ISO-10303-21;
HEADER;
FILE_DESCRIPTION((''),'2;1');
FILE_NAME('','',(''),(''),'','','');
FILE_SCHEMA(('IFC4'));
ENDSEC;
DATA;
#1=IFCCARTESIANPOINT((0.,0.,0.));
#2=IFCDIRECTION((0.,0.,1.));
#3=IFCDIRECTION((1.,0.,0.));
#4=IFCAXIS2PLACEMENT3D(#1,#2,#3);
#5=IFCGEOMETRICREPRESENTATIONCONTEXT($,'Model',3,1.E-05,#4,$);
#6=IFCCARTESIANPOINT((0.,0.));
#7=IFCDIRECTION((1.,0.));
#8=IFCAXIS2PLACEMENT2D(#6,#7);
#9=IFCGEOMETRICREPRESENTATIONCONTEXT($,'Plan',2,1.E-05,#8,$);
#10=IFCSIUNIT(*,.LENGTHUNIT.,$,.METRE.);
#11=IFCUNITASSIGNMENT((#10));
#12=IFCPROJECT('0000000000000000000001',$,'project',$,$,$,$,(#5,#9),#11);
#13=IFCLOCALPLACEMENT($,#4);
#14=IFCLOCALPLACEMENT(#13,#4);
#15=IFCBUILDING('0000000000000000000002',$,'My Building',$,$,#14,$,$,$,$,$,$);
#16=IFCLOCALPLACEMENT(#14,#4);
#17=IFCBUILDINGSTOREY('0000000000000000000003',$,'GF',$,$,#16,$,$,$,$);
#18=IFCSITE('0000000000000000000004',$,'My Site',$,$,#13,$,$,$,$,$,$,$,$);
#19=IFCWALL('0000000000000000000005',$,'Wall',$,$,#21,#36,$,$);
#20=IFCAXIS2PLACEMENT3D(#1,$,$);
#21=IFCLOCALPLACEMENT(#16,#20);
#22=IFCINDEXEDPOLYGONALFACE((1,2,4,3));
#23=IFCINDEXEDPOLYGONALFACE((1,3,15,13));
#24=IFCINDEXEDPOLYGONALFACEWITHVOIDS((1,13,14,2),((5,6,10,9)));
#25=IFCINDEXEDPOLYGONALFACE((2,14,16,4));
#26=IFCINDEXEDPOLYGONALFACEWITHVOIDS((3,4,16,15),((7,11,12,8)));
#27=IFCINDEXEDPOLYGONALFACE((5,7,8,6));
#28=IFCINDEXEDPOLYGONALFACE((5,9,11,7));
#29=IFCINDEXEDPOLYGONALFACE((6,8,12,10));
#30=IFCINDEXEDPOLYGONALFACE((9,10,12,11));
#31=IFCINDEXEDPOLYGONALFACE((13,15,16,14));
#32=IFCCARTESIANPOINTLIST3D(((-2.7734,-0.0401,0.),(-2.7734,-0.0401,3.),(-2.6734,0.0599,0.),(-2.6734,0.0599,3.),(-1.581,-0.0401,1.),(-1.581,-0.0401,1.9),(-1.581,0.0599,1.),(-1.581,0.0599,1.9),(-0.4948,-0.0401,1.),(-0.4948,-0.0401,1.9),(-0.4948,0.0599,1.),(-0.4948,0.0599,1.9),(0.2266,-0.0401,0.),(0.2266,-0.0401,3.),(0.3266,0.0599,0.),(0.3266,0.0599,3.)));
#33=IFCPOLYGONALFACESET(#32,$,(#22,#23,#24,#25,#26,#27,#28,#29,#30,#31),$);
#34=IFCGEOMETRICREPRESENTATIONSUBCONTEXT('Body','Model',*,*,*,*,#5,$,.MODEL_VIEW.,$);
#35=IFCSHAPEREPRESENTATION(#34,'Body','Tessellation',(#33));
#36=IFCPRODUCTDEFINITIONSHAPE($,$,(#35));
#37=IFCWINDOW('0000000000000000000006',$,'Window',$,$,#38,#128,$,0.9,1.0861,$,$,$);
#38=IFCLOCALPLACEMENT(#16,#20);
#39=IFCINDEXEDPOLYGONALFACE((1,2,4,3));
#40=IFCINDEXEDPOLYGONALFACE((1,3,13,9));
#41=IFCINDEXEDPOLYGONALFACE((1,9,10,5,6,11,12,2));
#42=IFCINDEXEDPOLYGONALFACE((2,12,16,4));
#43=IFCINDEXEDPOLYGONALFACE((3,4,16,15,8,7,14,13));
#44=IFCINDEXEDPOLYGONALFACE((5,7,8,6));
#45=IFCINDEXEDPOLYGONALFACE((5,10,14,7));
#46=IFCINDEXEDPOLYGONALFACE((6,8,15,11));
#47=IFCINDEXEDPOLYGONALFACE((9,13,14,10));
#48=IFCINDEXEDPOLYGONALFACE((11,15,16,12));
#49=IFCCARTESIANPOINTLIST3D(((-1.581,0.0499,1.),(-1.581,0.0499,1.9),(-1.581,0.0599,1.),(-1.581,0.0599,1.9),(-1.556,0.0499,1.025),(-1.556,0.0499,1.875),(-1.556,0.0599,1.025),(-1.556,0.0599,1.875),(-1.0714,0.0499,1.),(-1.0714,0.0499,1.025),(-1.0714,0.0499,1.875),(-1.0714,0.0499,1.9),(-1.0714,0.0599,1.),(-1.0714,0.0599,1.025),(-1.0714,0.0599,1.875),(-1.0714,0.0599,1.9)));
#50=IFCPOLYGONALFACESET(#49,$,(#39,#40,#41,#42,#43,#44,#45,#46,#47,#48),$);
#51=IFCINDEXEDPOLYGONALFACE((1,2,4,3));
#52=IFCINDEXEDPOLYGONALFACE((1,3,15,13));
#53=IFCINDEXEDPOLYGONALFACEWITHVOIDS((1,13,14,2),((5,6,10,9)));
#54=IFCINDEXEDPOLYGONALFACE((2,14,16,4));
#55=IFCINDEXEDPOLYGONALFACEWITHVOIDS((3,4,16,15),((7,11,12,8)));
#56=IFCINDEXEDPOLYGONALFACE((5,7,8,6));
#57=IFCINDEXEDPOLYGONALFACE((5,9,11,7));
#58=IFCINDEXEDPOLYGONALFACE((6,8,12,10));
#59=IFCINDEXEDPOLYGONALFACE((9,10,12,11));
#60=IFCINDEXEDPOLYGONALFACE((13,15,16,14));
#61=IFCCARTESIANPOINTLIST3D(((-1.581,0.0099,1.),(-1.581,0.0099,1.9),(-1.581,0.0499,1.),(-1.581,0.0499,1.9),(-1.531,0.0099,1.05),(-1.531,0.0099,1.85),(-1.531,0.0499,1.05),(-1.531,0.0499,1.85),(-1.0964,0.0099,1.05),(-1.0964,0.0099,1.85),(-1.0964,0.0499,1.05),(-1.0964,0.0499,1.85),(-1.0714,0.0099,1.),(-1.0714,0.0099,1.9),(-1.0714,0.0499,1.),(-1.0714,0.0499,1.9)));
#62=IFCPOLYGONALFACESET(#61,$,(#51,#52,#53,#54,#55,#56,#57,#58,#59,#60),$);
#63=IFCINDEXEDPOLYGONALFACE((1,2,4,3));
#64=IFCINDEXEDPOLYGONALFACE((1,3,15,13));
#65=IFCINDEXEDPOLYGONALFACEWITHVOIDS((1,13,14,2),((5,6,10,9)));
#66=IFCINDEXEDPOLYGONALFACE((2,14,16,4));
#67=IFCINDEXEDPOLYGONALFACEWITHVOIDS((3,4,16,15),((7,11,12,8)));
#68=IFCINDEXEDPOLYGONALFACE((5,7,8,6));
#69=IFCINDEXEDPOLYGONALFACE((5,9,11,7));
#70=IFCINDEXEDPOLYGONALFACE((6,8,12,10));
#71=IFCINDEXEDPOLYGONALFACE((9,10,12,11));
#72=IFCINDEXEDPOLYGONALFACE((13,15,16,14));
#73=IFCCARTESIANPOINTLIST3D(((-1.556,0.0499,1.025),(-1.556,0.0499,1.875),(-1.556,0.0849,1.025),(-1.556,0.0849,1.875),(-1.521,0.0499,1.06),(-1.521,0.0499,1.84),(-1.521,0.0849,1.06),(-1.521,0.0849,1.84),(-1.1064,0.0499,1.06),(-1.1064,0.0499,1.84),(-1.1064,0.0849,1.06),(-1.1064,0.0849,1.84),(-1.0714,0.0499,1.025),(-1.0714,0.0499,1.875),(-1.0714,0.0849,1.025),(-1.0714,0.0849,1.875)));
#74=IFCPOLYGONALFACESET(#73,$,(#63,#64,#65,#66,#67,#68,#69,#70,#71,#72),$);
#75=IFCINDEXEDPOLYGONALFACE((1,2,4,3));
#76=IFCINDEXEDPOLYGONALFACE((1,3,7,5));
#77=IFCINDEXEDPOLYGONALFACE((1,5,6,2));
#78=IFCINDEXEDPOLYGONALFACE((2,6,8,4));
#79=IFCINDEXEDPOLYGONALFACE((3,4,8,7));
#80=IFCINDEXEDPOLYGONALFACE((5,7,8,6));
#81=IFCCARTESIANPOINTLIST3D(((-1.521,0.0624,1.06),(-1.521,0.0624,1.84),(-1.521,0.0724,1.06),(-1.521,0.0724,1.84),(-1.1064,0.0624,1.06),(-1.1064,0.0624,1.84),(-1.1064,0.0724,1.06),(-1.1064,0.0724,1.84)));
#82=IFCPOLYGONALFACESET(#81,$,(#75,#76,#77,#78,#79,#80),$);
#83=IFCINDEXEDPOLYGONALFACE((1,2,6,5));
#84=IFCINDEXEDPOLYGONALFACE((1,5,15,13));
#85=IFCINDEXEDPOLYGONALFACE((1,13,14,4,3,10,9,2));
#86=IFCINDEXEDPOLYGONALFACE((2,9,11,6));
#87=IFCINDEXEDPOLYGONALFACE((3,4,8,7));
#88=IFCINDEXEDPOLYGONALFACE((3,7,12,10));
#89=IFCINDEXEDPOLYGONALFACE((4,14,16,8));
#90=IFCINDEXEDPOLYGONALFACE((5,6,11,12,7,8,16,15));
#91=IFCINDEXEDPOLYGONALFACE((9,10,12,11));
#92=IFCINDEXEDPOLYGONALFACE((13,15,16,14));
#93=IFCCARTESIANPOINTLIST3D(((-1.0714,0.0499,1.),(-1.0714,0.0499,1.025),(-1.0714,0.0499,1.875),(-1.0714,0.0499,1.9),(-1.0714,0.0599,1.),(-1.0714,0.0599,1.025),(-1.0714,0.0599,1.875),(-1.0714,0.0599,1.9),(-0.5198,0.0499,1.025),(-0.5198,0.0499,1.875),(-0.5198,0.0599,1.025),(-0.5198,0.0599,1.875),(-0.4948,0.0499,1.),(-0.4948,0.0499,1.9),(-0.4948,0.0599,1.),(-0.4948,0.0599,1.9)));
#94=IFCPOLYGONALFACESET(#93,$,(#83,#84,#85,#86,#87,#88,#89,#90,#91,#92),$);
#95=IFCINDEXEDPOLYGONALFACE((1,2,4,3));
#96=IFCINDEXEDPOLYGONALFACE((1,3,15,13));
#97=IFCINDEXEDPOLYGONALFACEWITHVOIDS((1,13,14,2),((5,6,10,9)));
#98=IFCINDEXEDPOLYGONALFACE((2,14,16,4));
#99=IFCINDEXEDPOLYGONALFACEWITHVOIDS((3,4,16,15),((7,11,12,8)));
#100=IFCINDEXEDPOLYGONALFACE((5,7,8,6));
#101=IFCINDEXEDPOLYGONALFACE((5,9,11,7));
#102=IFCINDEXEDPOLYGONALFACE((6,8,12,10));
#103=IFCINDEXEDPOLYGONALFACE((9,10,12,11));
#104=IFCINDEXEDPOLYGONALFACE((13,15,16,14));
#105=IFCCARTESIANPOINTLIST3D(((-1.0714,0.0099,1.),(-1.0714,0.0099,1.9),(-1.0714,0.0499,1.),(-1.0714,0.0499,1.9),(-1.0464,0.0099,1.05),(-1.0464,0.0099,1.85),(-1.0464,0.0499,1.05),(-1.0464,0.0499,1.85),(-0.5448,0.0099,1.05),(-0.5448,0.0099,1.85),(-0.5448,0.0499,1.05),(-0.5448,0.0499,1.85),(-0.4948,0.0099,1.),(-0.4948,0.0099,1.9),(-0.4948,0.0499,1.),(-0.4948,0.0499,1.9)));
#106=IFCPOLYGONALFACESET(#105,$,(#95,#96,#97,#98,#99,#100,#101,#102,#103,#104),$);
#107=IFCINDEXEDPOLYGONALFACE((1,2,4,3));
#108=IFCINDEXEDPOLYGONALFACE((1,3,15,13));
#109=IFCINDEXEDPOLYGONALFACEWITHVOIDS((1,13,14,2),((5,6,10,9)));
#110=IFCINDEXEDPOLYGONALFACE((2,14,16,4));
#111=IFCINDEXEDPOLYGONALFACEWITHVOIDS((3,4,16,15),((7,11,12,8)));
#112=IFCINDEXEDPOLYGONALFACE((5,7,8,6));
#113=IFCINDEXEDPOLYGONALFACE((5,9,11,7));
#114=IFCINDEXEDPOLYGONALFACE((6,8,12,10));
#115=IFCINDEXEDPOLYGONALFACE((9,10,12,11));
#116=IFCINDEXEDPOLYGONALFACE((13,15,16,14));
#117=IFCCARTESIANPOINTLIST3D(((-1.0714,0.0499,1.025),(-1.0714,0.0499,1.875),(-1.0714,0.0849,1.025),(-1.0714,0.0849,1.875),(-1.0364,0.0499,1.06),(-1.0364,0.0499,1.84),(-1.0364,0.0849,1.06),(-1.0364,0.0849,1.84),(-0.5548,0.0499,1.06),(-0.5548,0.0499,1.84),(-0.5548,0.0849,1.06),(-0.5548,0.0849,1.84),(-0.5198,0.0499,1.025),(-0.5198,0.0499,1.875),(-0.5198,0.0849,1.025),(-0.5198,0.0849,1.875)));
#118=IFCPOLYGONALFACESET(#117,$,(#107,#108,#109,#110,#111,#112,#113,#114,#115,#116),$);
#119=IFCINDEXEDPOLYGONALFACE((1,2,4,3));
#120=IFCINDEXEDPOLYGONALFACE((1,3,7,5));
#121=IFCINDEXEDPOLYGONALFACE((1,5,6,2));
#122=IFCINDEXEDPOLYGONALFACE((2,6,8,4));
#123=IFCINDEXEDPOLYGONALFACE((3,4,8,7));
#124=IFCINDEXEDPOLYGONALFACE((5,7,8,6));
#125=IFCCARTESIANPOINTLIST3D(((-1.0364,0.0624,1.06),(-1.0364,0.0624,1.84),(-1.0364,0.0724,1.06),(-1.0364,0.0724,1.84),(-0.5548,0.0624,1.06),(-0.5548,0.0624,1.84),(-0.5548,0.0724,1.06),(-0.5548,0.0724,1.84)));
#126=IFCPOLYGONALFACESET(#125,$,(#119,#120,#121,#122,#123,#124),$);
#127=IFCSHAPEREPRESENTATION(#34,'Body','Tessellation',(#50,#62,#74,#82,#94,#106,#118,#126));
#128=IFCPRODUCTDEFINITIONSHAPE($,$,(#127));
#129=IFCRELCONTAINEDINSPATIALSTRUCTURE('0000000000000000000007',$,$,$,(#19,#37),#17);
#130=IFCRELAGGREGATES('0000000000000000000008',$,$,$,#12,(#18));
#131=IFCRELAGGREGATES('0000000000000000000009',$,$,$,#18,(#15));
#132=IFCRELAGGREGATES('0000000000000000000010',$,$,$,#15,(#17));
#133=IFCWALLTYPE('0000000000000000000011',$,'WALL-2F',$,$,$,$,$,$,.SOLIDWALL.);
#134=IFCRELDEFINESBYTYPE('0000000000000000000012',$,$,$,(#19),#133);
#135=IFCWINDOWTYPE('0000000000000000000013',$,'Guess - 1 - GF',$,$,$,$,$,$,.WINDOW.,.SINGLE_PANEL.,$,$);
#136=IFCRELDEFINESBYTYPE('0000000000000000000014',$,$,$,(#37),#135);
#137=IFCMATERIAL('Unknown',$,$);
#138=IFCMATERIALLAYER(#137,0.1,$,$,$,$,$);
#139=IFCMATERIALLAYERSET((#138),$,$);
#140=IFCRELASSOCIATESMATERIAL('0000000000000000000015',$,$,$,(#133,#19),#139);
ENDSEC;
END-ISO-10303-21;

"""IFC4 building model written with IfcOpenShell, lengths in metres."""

from ifc_helpers import new_model, entity, si_unit, frame, origin_with_axes, origin_2d_with_axis, place, context, subcontext, project, spatial, line, indexed_curve, outline, extrude, shape, source, transform, mapped, material, layer, layer_set, layer_usage, type_object, type_shapes, element, fill, save


model = new_model("IFC4")

# Units and contexts
model_context = context("Model", 3, precision=1e-05, world=origin_with_axes())
plan_context = context("Plan", 2, precision=1e-05, world=origin_2d_with_axis())
body_context_1 = subcontext(model_context, "Body", "Model", "MODEL_VIEW")
body_context_2 = subcontext(plan_context, "Body", "Plan", "PLAN_VIEW")
ifc_project = project(units=[si_unit("LENGTHUNIT", "METRE")], contexts=[model_context, plan_context])

# Site, building, storey
site_placement = place(None, origin_with_axes())
site = spatial("IfcSite", under=ifc_project, at=site_placement, Name="My Site")
building_placement = place(site_placement, origin_with_axes())
building = spatial("IfcBuilding", under=site, at=building_placement, Name="My Building")
storey_placement = place(building_placement, origin_with_axes())
storey = spatial("IfcBuildingStorey", under=building, at=storey_placement, Name="GF")

# Shared definitions
ifc_material_1 = material(Name="Unknown")

# Shared definitions
ifc_layer_1 = layer(ifc_material_1, 0.1)
ifc_layer_set_1 = layer_set([ifc_layer_1])
wall_type_1 = type_object("IfcWallType", Name="WALL-2F", PredefinedType="SOLIDWALL", material=ifc_layer_set_1)

# Wall, opening, window
ifc_layer_usage_1 = layer_usage(ifc_layer_set_1, "AXIS2", "POSITIVE", 0.0)
wall_1_placement = place(storey_placement, frame((-2.7734, -0.0401, 0.0), z_axis=(0.0, 0.0, 1.0), x_axis=(1.0, 0.0, 0.0)))
wall_1 = element("IfcWall", 1, at=wall_1_placement, inside=storey, type_object=wall_type_1, material=ifc_layer_usage_1, Name="Wall", context=body_context_1, shape_type="SweptSolid", body=[
    extrude(outline(indexed_curve([(0.0, 0.0), (0.1, 0.1), (3.1, 0.1), (3.0, 0.0)], segments=[line(1, 2, 3, 4, 1)])), origin_with_axes(), (0.0, 0.0, 1.0), 3.0),
])
shared_shape_1 = source(origin_with_axes(), body_context_1, "Body", "SweptSolid", [
    extrude(outline(indexed_curve([(0.0, 0.0), (1.0861, 0.0), (1.0861, 0.9), (0.0, 0.9)], segments=[line(1, 2, 3, 4, 1)])), frame((0.0, -0.6, 0.0), z_axis=(0.0, -1.0, 0.0), x_axis=(1.0, 0.0, 0.0)), (0.0, 0.0, -1.0), 1.2),
])
opening_1_placement = place(wall_1_placement, frame((1.1924, 0.0, 1.0), z_axis=(0.0, 0.0, 1.0), x_axis=(1.0, 0.0, 0.0)))
opening_1 = element("IfcOpeningElement", 2, at=opening_1_placement, cuts=wall_1, PredefinedType="OPENING", context=body_context_1, shape_type="MappedRepresentation", body=[
    mapped(shared_shape_1, transform((0.0, 0.0, 0.0), x_axis=(1.0, 0.0, 0.0), y_axis=(0.0, 1.0, 0.0), z_axis=(0.0, 0.0, 1.0), scale=1.0)),
])
window_type_1 = type_object("IfcWindowType", Name="Guess - 1 - GF", PartitioningType="SINGLE_PANEL", PredefinedType="WINDOW")
shared_shape_2 = source(origin_with_axes(), body_context_1, "Body", "SweptSolid", [
    extrude(outline(indexed_curve([(0.5096, 0.0), (0.0, 0.0), (0.0, 0.9), (0.5096, 0.9), (0.5096, 0.875), (0.025, 0.875), (0.025, 0.025), (0.5096, 0.025)], segments=[line(1, 2, 3, 4, 5, 6, 7, 8, 1)])), frame((0.0, 0.09, 0.0), z_axis=(0.0, -1.0, 0.0), x_axis=(1.0, 0.0, 0.0)), (0.0, 0.0, -1.0), 0.01),
    extrude(outline(indexed_curve([(0.0, 0.0), (0.5096, 0.0), (0.5096, 0.9), (0.0, 0.9)], segments=[line(1, 2, 3, 4, 1)]), holes=[indexed_curve([(0.05, 0.05), (0.4846, 0.05), (0.4846, 0.85), (0.05, 0.85)], segments=[line(1, 2, 3, 4, 1)])]), frame((0.0, 0.05, 0.0), z_axis=(0.0, -1.0, 0.0), x_axis=(1.0, 0.0, 0.0)), (0.0, 0.0, -1.0), 0.04),
    extrude(outline(indexed_curve([(0.0, 0.0), (0.4846, 0.0), (0.4846, 0.85), (0.0, 0.85)], segments=[line(1, 2, 3, 4, 1)]), holes=[indexed_curve([(0.035, 0.035), (0.4496, 0.035), (0.4496, 0.815), (0.035, 0.815)], segments=[line(1, 2, 3, 4, 1)])]), frame((0.025, 0.09, 0.025), z_axis=(0.0, -1.0, 0.0), x_axis=(1.0, 0.0, 0.0)), (0.0, 0.0, -1.0), 0.035),
    extrude(outline(indexed_curve([(0.035, 0.035), (0.4496, 0.035), (0.4496, 0.815), (0.035, 0.815)], segments=[line(1, 2, 3, 4, 1)])), frame((0.025, 0.1025, 0.025), z_axis=(0.0, -1.0, 0.0), x_axis=(1.0, 0.0, 0.0)), (0.0, 0.0, -1.0), 0.01),
    extrude(outline(indexed_curve([(0.0, 0.9), (0.5766, 0.9), (0.5766, 0.0), (0.0, 0.0), (0.0, 0.025), (0.5516, 0.025), (0.5516, 0.875), (0.0, 0.875)], segments=[line(1, 2, 3, 4, 5, 6, 7, 8, 1)])), frame((0.5096, 0.09, 0.0), z_axis=(0.0, -1.0, 0.0), x_axis=(1.0, 0.0, 0.0)), (0.0, 0.0, -1.0), 0.01),
    extrude(outline(indexed_curve([(0.0, 0.0), (0.5766, 0.0), (0.5766, 0.9), (0.0, 0.9)], segments=[line(1, 2, 3, 4, 1)]), holes=[indexed_curve([(0.025, 0.05), (0.5266, 0.05), (0.5266, 0.85), (0.025, 0.85)], segments=[line(1, 2, 3, 4, 1)])]), frame((0.5096, 0.05, 0.0), z_axis=(0.0, -1.0, 0.0), x_axis=(1.0, 0.0, 0.0)), (0.0, 0.0, -1.0), 0.04),
    extrude(outline(indexed_curve([(0.0, 0.0), (0.5516, 0.0), (0.5516, 0.85), (0.0, 0.85)], segments=[line(1, 2, 3, 4, 1)]), holes=[indexed_curve([(0.035, 0.035), (0.5166, 0.035), (0.5166, 0.815), (0.035, 0.815)], segments=[line(1, 2, 3, 4, 1)])]), frame((0.5096, 0.09, 0.025), z_axis=(0.0, -1.0, 0.0), x_axis=(1.0, 0.0, 0.0)), (0.0, 0.0, -1.0), 0.035),
    extrude(outline(indexed_curve([(0.035, 0.035), (0.5166, 0.035), (0.5166, 0.815), (0.035, 0.815)], segments=[line(1, 2, 3, 4, 1)])), frame((0.5096, 0.1025, 0.025), z_axis=(0.0, -1.0, 0.0), x_axis=(1.0, 0.0, 0.0)), (0.0, 0.0, -1.0), 0.01),
])
shared_shape_3 = source(origin_with_axes(), body_context_2, "Body", "Curve2D", [
    entity("IfcIndexedPolyCurve", entity("IfcCartesianPointList2D", [[0.05, 0.05], [0.4846, 0.05]])),
    entity("IfcIndexedPolyCurve", entity("IfcCartesianPointList2D", [[0.0, 0.1], [0.025, 0.1], [0.025, 0.09], [0.05, 0.09], [0.05, 0.05], [0.0, 0.05]]), [entity("IfcLineIndex", [1, 2, 3, 4, 5, 6, 1])]),
    entity("IfcIndexedPolyCurve", entity("IfcCartesianPointList2D", [[0.5096, 0.1], [0.5096, 0.1], [0.5096, 0.09], [0.4846, 0.09], [0.4846, 0.05], [0.5096, 0.05]])),
    entity("IfcIndexedPolyCurve", entity("IfcCartesianPointList2D", [[0.025, 0.09], [0.06, 0.09], [0.06, 0.125], [0.025, 0.125]]), [entity("IfcLineIndex", [1, 2, 3, 4, 1])]),
    entity("IfcIndexedPolyCurve", entity("IfcCartesianPointList2D", [[0.5096, 0.09], [0.4746, 0.09], [0.4746, 0.125], [0.5096, 0.125]]), [entity("IfcLineIndex", [1, 2, 3, 4, 1])]),
    entity("IfcIndexedPolyCurve", entity("IfcCartesianPointList2D", [[0.06, 0.09], [0.4746, 0.09]])),
    entity("IfcIndexedPolyCurve", entity("IfcCartesianPointList2D", [[0.06, 0.125], [0.4746, 0.125]])),
    entity("IfcIndexedPolyCurve", entity("IfcCartesianPointList2D", [[0.06, 0.1075], [0.4746, 0.1075]])),
    entity("IfcIndexedPolyCurve", entity("IfcCartesianPointList2D", [[0.5346, 0.05], [1.0361, 0.05]])),
    entity("IfcIndexedPolyCurve", entity("IfcCartesianPointList2D", [[0.5096, 0.1], [0.5096, 0.1], [0.5096, 0.09], [0.5346, 0.09], [0.5346, 0.05], [0.5096, 0.05]])),
    entity("IfcIndexedPolyCurve", entity("IfcCartesianPointList2D", [[1.0861, 0.1], [1.0611, 0.1], [1.0611, 0.09], [1.0361, 0.09], [1.0361, 0.05], [1.0861, 0.05]]), [entity("IfcLineIndex", [1, 2, 3, 4, 5, 6, 1])]),
    entity("IfcIndexedPolyCurve", entity("IfcCartesianPointList2D", [[0.5096, 0.09], [0.5446, 0.09], [0.5446, 0.125], [0.5096, 0.125]]), [entity("IfcLineIndex", [1, 2, 3, 4, 1])]),
    entity("IfcIndexedPolyCurve", entity("IfcCartesianPointList2D", [[1.0611, 0.09], [1.0261, 0.09], [1.0261, 0.125], [1.0611, 0.125]]), [entity("IfcLineIndex", [1, 2, 3, 4, 1])]),
    entity("IfcIndexedPolyCurve", entity("IfcCartesianPointList2D", [[0.5446, 0.09], [1.0261, 0.09]])),
    entity("IfcIndexedPolyCurve", entity("IfcCartesianPointList2D", [[0.5446, 0.125], [1.0261, 0.125]])),
    entity("IfcIndexedPolyCurve", entity("IfcCartesianPointList2D", [[0.5446, 0.1075], [1.0261, 0.1075]])),
])
type_shapes(window_type_1, [shared_shape_2, shared_shape_3])
window_1_placement = place(opening_1_placement, frame((0.0, 0.0, 0.0), z_axis=(0.0, 0.0, 1.0), x_axis=(1.0, 0.0, 0.0)))
window_1 = element("IfcWindow", 3, at=window_1_placement, inside=storey, type_object=window_type_1, Name="Window", OverallHeight=0.9, OverallWidth=1.0861, shapes=[
    shape(body_context_1, "Body", "MappedRepresentation", [mapped(shared_shape_2, transform((0.0, 0.0, 0.0), x_axis=(1.0, 0.0, 0.0), y_axis=(0.0, 1.0, 0.0), z_axis=(0.0, 0.0, 1.0), scale=1.0))]),
    shape(body_context_2, "Body", "MappedRepresentation", [mapped(shared_shape_3, transform((0.0, 0.0, 0.0), x_axis=(1.0, 0.0, 0.0), y_axis=(0.0, 1.0, 0.0), z_axis=(0.0, 0.0, 1.0), scale=1.0))]),
])
fill(opening_1, window_1)

save(model, "model.ifc")
